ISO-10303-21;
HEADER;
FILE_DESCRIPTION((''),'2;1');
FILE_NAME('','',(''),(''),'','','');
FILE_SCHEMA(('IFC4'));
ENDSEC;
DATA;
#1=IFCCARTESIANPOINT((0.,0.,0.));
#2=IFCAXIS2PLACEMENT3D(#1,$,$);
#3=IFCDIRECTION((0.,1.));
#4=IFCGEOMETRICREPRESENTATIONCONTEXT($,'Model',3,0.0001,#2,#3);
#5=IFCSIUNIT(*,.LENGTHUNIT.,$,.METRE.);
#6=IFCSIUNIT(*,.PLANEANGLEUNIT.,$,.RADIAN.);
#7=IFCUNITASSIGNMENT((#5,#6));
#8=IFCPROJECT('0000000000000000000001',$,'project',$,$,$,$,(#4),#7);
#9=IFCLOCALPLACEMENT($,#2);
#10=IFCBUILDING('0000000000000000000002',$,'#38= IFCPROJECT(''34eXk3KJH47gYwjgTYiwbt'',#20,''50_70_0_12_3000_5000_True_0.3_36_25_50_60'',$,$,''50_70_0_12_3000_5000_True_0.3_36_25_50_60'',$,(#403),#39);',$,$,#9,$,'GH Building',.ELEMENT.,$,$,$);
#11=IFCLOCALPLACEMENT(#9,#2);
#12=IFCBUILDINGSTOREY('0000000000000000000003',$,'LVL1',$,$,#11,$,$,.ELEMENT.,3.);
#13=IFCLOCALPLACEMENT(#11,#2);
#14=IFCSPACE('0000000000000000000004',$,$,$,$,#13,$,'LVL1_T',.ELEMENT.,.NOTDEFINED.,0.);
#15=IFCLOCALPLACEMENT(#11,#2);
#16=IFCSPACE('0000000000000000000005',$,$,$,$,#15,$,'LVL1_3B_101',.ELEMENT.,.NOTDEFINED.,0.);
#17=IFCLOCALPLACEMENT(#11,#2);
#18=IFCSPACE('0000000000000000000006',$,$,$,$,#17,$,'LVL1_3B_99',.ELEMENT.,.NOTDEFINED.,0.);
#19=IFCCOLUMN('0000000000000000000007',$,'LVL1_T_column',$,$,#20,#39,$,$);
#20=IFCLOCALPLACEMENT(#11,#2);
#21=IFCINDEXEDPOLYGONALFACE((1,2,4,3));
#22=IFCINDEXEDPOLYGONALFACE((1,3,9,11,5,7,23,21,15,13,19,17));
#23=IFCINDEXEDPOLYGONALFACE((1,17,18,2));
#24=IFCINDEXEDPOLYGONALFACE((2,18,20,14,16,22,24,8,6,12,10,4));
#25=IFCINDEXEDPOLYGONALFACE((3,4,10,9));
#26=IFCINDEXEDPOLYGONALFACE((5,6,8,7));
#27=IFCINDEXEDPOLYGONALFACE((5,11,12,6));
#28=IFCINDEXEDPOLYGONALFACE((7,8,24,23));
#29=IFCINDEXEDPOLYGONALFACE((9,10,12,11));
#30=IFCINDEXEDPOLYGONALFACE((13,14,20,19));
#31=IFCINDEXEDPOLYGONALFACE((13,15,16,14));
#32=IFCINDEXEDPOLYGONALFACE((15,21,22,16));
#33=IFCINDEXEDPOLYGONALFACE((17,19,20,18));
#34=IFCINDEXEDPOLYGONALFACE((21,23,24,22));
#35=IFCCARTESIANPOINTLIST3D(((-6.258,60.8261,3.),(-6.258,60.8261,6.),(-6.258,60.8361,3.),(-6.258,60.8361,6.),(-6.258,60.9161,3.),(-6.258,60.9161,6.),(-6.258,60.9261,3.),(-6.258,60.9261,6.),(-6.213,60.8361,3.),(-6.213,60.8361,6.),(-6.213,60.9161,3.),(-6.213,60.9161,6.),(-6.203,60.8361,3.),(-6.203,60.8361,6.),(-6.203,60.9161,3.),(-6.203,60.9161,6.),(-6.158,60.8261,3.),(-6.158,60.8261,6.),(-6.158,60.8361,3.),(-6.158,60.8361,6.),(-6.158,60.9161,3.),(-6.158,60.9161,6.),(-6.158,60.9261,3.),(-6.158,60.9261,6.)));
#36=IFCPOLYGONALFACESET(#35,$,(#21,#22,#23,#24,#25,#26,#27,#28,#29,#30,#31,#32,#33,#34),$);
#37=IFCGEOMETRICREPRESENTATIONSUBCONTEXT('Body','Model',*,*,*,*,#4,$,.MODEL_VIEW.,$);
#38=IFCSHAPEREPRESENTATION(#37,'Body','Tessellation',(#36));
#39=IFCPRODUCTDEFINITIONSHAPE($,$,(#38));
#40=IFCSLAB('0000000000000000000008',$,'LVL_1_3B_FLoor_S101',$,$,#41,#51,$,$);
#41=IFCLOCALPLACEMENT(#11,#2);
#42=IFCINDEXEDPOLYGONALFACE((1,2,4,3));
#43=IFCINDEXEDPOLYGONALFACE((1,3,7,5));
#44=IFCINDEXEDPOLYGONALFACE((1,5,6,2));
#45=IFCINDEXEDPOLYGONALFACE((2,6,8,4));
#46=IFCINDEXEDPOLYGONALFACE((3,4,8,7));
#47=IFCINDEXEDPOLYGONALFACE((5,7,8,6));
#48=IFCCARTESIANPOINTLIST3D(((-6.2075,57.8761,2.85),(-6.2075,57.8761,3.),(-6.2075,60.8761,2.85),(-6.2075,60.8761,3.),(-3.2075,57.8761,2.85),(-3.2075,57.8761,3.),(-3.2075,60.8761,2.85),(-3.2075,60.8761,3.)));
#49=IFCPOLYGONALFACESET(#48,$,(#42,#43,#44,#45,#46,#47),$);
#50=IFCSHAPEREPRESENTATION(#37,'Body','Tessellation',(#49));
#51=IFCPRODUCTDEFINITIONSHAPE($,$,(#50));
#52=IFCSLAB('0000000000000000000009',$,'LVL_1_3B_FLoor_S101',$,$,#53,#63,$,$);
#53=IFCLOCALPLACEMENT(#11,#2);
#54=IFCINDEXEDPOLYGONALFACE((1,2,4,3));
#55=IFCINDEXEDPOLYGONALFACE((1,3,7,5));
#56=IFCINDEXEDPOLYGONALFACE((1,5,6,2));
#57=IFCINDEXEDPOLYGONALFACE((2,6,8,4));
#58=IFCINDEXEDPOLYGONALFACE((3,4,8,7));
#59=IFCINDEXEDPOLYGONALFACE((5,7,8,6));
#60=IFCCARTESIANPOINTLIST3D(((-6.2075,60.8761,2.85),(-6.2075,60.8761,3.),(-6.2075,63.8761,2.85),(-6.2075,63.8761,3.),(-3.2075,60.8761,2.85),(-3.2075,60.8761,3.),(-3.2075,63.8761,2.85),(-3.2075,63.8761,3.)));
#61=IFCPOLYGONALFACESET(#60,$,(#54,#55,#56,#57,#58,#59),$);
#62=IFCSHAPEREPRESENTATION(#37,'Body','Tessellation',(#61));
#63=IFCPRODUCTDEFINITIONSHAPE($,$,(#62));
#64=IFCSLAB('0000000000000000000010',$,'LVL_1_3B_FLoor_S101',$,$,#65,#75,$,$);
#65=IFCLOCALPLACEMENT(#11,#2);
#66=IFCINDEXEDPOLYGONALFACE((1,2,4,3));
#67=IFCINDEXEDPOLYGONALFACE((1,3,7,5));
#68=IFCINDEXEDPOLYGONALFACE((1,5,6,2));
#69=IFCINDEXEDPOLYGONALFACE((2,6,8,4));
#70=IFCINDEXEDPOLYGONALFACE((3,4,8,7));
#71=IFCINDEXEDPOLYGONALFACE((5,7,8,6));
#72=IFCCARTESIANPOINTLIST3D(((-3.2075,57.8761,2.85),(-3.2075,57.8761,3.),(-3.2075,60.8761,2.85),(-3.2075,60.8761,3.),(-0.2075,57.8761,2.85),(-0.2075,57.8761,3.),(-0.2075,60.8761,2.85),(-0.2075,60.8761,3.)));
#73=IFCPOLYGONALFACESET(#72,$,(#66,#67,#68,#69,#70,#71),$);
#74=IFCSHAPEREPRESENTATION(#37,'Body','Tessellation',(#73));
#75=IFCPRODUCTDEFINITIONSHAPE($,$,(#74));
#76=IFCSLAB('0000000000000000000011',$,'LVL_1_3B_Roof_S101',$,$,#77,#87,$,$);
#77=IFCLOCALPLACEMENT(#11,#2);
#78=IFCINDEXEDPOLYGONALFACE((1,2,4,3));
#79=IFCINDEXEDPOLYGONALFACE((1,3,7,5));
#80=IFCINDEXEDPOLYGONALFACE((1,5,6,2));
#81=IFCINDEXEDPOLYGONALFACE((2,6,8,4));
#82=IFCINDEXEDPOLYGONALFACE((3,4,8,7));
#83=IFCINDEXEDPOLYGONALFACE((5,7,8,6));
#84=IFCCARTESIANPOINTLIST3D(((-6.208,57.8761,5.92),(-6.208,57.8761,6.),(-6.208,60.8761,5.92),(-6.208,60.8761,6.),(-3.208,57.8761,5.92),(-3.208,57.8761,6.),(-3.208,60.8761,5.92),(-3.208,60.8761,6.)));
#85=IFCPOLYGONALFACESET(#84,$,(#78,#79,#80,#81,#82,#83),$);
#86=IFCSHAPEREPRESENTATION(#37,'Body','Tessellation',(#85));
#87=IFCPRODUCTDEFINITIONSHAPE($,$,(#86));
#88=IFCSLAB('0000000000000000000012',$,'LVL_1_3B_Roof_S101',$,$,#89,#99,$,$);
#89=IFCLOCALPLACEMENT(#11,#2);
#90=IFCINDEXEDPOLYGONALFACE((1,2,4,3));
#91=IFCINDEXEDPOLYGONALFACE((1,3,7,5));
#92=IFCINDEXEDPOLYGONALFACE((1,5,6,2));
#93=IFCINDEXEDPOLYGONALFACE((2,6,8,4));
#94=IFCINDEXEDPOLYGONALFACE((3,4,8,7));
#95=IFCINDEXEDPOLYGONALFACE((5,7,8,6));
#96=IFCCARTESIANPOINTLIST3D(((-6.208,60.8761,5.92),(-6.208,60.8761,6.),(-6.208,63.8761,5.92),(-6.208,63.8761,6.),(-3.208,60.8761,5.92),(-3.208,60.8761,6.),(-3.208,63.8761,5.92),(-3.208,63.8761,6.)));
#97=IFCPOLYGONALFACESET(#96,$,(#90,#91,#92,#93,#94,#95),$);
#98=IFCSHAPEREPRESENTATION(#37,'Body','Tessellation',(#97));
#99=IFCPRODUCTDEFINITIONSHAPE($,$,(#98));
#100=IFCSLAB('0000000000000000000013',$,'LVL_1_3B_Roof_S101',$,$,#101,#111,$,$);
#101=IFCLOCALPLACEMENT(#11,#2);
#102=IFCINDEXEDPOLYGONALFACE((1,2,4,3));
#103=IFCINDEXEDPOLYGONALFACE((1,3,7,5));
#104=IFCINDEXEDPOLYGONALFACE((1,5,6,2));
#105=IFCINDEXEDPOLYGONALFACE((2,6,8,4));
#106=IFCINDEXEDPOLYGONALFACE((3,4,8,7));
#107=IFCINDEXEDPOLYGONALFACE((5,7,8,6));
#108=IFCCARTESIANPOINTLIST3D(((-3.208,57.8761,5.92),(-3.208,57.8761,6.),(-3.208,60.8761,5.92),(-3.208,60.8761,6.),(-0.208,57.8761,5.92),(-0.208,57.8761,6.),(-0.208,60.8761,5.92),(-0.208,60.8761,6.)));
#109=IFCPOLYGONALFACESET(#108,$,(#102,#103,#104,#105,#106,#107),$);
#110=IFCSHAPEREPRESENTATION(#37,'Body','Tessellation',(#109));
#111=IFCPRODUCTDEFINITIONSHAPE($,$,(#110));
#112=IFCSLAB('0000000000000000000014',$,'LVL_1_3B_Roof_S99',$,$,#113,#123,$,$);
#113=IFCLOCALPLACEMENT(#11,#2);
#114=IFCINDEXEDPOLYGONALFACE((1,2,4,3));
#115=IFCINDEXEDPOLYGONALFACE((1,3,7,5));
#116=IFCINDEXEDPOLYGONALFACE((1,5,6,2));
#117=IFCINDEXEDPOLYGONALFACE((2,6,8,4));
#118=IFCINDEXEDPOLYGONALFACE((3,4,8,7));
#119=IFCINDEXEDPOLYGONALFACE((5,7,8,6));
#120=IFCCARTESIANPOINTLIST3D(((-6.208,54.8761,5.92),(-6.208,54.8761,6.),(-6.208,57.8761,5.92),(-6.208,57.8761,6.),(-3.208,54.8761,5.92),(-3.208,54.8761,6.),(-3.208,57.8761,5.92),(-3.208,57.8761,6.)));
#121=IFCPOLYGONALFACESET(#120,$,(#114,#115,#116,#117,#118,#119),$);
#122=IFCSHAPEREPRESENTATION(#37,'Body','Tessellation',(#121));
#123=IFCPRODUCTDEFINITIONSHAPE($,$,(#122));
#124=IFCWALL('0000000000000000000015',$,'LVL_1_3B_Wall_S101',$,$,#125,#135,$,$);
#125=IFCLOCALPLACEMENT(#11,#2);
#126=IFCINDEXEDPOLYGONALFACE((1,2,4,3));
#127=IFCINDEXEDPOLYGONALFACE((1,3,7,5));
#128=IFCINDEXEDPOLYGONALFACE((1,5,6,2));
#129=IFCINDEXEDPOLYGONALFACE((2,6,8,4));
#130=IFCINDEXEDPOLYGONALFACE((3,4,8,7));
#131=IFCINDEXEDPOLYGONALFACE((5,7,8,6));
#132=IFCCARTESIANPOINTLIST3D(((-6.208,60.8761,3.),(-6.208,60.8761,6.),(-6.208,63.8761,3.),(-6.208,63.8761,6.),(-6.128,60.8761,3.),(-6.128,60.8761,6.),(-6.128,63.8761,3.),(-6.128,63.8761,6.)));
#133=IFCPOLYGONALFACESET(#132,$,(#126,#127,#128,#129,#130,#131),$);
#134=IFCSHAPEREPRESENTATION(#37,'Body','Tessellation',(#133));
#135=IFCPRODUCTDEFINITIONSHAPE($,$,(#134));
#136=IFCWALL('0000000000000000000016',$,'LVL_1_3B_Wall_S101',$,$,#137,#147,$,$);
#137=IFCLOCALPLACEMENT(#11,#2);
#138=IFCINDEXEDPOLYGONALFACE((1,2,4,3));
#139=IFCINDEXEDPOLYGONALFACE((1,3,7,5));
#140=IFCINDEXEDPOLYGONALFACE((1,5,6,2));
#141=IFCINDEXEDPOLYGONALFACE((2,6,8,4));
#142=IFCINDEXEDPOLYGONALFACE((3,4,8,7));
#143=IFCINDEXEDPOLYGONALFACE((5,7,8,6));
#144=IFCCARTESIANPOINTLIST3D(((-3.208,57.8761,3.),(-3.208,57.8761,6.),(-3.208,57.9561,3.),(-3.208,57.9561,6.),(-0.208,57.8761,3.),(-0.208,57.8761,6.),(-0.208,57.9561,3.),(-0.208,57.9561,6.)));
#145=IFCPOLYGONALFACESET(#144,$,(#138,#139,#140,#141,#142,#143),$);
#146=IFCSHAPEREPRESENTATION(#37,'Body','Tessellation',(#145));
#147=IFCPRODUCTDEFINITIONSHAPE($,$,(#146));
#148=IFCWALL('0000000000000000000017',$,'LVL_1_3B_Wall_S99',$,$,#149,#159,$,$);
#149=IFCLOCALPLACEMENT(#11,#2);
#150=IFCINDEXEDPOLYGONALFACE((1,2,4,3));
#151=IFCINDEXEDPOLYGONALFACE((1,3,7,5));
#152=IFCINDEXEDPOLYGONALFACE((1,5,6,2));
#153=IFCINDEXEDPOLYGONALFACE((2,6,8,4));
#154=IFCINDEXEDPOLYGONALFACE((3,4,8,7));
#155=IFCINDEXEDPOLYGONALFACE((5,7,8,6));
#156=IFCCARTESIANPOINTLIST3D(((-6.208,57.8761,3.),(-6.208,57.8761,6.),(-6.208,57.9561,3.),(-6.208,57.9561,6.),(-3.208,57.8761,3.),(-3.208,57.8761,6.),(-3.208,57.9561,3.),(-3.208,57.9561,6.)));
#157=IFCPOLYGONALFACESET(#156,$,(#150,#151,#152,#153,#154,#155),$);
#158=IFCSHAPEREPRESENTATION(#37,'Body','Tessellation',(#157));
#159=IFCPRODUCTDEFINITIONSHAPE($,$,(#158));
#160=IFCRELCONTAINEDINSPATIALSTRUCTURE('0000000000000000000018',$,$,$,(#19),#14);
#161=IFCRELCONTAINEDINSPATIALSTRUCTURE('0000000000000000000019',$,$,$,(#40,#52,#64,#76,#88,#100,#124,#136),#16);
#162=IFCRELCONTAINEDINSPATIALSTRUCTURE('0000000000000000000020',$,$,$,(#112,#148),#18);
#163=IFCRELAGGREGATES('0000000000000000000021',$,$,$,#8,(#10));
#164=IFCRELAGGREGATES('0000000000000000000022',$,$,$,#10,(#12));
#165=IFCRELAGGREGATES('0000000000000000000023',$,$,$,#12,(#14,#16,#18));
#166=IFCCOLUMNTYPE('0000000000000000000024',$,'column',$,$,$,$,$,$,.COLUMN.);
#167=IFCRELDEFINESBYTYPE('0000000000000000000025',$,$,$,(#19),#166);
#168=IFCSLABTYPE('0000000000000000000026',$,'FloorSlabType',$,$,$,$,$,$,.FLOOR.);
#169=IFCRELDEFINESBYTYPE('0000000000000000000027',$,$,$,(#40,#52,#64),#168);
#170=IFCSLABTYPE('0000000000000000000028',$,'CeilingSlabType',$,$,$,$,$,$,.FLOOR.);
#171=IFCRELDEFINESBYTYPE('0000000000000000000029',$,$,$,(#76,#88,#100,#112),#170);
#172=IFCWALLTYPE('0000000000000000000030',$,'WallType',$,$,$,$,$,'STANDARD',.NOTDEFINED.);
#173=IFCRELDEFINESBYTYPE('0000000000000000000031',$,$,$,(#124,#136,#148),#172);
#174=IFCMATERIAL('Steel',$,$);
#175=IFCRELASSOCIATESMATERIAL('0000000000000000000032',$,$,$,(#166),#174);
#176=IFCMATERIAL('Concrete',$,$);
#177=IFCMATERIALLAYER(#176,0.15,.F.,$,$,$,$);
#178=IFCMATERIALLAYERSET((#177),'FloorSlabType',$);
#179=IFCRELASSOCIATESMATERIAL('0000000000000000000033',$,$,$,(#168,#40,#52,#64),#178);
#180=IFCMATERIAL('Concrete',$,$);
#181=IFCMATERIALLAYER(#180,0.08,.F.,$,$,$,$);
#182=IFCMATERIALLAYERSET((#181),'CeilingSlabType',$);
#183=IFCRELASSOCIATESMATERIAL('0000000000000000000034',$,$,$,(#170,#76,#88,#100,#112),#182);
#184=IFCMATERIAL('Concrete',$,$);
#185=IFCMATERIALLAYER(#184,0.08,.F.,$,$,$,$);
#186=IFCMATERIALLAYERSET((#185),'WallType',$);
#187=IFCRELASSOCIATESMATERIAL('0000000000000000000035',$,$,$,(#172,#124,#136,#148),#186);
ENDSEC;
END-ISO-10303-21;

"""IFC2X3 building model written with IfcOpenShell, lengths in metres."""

from ifc_helpers import new_model, si_unit, direction, frame, frame_2d, origin, origin_2d, place, context, subcontext, project, spatial, rectangle, i_section, extrude, material, layer, layer_set, layer_usage, type_object, element, save


model = new_model("IFC2X3")

# Units and contexts
model_context = context("Model", 3, precision=0.0001, world=origin(), true_north=direction((0.0, 1.0)))
body_context = subcontext(model_context, "Body", "Model", "MODEL_VIEW")
ifc_project = project(units=[si_unit("LENGTHUNIT", "METRE"), si_unit("PLANEANGLEUNIT", "RADIAN")], contexts=[model_context])

# Building, storey, space
building_placement = place(None, origin())
building = spatial("IfcBuilding", under=ifc_project, at=building_placement, Name="#38= IFCPROJECT('34eXk3KJH47gYwjgTYiwbt',#20,'50_70_0_12_3000_5000_True_0.3_36_25_50_60',$,$,'50_70_0_12_3000_5000_True_0.3_36_25_50_60',$,(#403),#39);", LongName="GH Building", CompositionType="ELEMENT")
storey_placement = place(building_placement, origin())
storey = spatial("IfcBuildingStorey", under=building, at=storey_placement, Name="LVL1", CompositionType="ELEMENT", Elevation=3.0)
space_1_placement = place(storey_placement, origin())
space_1 = spatial("IfcSpace", under=storey, at=space_1_placement, LongName="LVL1_T", CompositionType="ELEMENT", InteriorOrExteriorSpace="NOTDEFINED", ElevationWithFlooring=0.0)

# Column
ifc_material_1 = material(Name="Steel")
column_type = type_object("IfcColumnType", Name="column", PredefinedType="COLUMN", material=ifc_material_1)
column_placement = place(space_1_placement, frame((-6.208, 60.8761, 3.0)))
element("IfcColumn", 1, at=column_placement, inside=space_1, type_object=column_type, Name="LVL1_T_column", context=body_context, shape_type="SweptSolid", body=[
    extrude(i_section(OverallWidth=0.1, OverallDepth=0.1, WebThickness=0.01, FlangeThickness=0.01, at=origin_2d()), origin(), (0.0, 0.0, 1.0), 3.0),
])

# Shared definitions
space_2_placement = place(storey_placement, origin())
space_2 = spatial("IfcSpace", under=storey, at=space_2_placement, LongName="LVL1_3B_101", CompositionType="ELEMENT", InteriorOrExteriorSpace="NOTDEFINED", ElevationWithFlooring=0.0)

# Slabs
ifc_material_2 = material(Name="Concrete")
ifc_layer_1 = layer(ifc_material_2, 0.15, ventilated=False)
ifc_layer_set_1 = layer_set([ifc_layer_1], Name="FloorSlabType")
ifc_layer_usage_1 = layer_usage(ifc_layer_set_1, "AXIS3", "NEGATIVE", -0.15)
slab_type_1 = type_object("IfcSlabType", Name="FloorSlabType", PredefinedType="FLOOR", material=ifc_layer_set_1)
slab_1_placement = place(space_2_placement, frame((-3.2075, 57.8761, 2.85), z_axis=(0.0, 0.0, 1.0), x_axis=(0.0, 1.0, 0.0)))
element("IfcSlab", 2, at=slab_1_placement, inside=space_2, type_object=slab_type_1, material=ifc_layer_usage_1, Name="LVL_1_3B_FLoor_S101", context=body_context, shape_type="SweptSolid", body=[
    extrude(rectangle(XDim=3.0, YDim=3.0, at=frame_2d((1.5, 1.5))), origin(), (0.0, 0.0, 1.0), 0.15),
])
ifc_layer_usage_2 = layer_usage(ifc_layer_set_1, "AXIS3", "NEGATIVE", -0.15)
slab_2_placement = place(space_2_placement, frame((-3.2075, 60.8761, 2.85), z_axis=(0.0, 0.0, 1.0), x_axis=(0.0, 1.0, 0.0)))
element("IfcSlab", 3, at=slab_2_placement, inside=space_2, type_object=slab_type_1, material=ifc_layer_usage_2, Name="LVL_1_3B_FLoor_S101", context=body_context, shape_type="SweptSolid", body=[
    extrude(rectangle(XDim=3.0, YDim=3.0, at=frame_2d((1.5, 1.5))), origin(), (0.0, 0.0, 1.0), 0.15),
])
ifc_layer_usage_3 = layer_usage(ifc_layer_set_1, "AXIS3", "NEGATIVE", -0.15)
slab_3_placement = place(space_2_placement, frame((-0.2075, 57.8761, 2.85), z_axis=(0.0, 0.0, 1.0), x_axis=(0.0, 1.0, 0.0)))
element("IfcSlab", 4, at=slab_3_placement, inside=space_2, type_object=slab_type_1, material=ifc_layer_usage_3, Name="LVL_1_3B_FLoor_S101", context=body_context, shape_type="SweptSolid", body=[
    extrude(rectangle(XDim=3.0, YDim=3.0, at=frame_2d((1.5, 1.5))), origin(), (0.0, 0.0, 1.0), 0.15),
])
ifc_material_3 = material(Name="Concrete")
ifc_layer_2 = layer(ifc_material_3, 0.08, ventilated=False)
ifc_layer_set_2 = layer_set([ifc_layer_2], Name="CeilingSlabType")
ifc_layer_usage_4 = layer_usage(ifc_layer_set_2, "AXIS3", "NEGATIVE", -0.08)
slab_type_2 = type_object("IfcSlabType", Name="CeilingSlabType", PredefinedType="FLOOR", material=ifc_layer_set_2)
slab_4_placement = place(space_2_placement, frame((-3.208, 57.8761, 5.92), z_axis=(0.0, 0.0, 1.0), x_axis=(0.0, 1.0, 0.0)))
element("IfcSlab", 5, at=slab_4_placement, inside=space_2, type_object=slab_type_2, material=ifc_layer_usage_4, Name="LVL_1_3B_Roof_S101", context=body_context, shape_type="SweptSolid", body=[
    extrude(rectangle(XDim=3.0, YDim=3.0, at=frame_2d((1.5, 1.5))), origin(), (0.0, 0.0, 1.0), 0.08),
])
ifc_layer_usage_5 = layer_usage(ifc_layer_set_2, "AXIS3", "NEGATIVE", -0.08)
slab_5_placement = place(space_2_placement, frame((-3.208, 60.8761, 5.92), z_axis=(0.0, 0.0, 1.0), x_axis=(0.0, 1.0, 0.0)))
element("IfcSlab", 6, at=slab_5_placement, inside=space_2, type_object=slab_type_2, material=ifc_layer_usage_5, Name="LVL_1_3B_Roof_S101", context=body_context, shape_type="SweptSolid", body=[
    extrude(rectangle(XDim=3.0, YDim=3.0, at=frame_2d((1.5, 1.5))), origin(), (0.0, 0.0, 1.0), 0.08),
])
ifc_layer_usage_6 = layer_usage(ifc_layer_set_2, "AXIS3", "NEGATIVE", -0.08)
slab_6_placement = place(space_2_placement, frame((-0.208, 57.8761, 5.92), z_axis=(0.0, 0.0, 1.0), x_axis=(0.0, 1.0, 0.0)))
element("IfcSlab", 7, at=slab_6_placement, inside=space_2, type_object=slab_type_2, material=ifc_layer_usage_6, Name="LVL_1_3B_Roof_S101", context=body_context, shape_type="SweptSolid", body=[
    extrude(rectangle(XDim=3.0, YDim=3.0, at=frame_2d((1.5, 1.5))), origin(), (0.0, 0.0, 1.0), 0.08),
])

# Shared definitions
space_3_placement = place(storey_placement, origin())
space_3 = spatial("IfcSpace", under=storey, at=space_3_placement, LongName="LVL1_3B_99", CompositionType="ELEMENT", InteriorOrExteriorSpace="NOTDEFINED", ElevationWithFlooring=0.0)

# Slab
ifc_layer_usage_7 = layer_usage(ifc_layer_set_2, "AXIS3", "NEGATIVE", -0.08)
slab_7_placement = place(space_3_placement, frame((-3.208, 57.8761, 5.92), z_axis=(0.0, 0.0, 1.0), x_axis=(0.0, -1.0, 0.0)))
element("IfcSlab", 8, at=slab_7_placement, inside=space_3, type_object=slab_type_2, material=ifc_layer_usage_7, Name="LVL_1_3B_Roof_S99", context=body_context, shape_type="SweptSolid", body=[
    extrude(rectangle(XDim=3.0, YDim=3.0, at=frame_2d((1.5, -1.5))), origin(), (0.0, 0.0, 1.0), 0.08),
])

# Shared definitions
ifc_material_4 = material(Name="Concrete")
ifc_layer_3 = layer(ifc_material_4, 0.08, ventilated=False)
ifc_layer_set_3 = layer_set([ifc_layer_3], Name="WallType")
wall_type = type_object("IfcWallType", Name="WallType", ElementType="STANDARD", PredefinedType="NOTDEFINED", material=ifc_layer_set_3)

# Walls
ifc_layer_usage_8 = layer_usage(ifc_layer_set_3, "AXIS2", "NEGATIVE", 0.0)
wall_1_placement = place(space_2_placement, frame((-6.208, 60.8761, 3.0), z_axis=(0.0, 0.0, 1.0), x_axis=(0.0, 1.0, 0.0)))
element("IfcWall", 9, at=wall_1_placement, inside=space_2, type_object=wall_type, material=ifc_layer_usage_8, Name="LVL_1_3B_Wall_S101", context=body_context, shape_type="SweptSolid", body=[
    extrude(rectangle(XDim=3.0, YDim=0.08, at=frame_2d((1.5, -0.04))), origin(), (0.0, 0.0, 1.0), 3.0),
])
ifc_layer_usage_9 = layer_usage(ifc_layer_set_3, "AXIS2", "NEGATIVE", 0.0)
wall_2_placement = place(space_2_placement, frame((-0.208, 57.8761, 3.0), z_axis=(0.0, 0.0, 1.0), x_axis=(-1.0, 0.0, 0.0)))
element("IfcWall", 10, at=wall_2_placement, inside=space_2, type_object=wall_type, material=ifc_layer_usage_9, Name="LVL_1_3B_Wall_S101", context=body_context, shape_type="SweptSolid", body=[
    extrude(rectangle(XDim=3.0, YDim=0.08, at=frame_2d((1.5, -0.04))), origin(), (0.0, 0.0, 1.0), 3.0),
])
ifc_layer_usage_10 = layer_usage(ifc_layer_set_3, "AXIS2", "NEGATIVE", 0.0)
wall_3_placement = place(space_3_placement, frame((-3.208, 57.8761, 3.0), z_axis=(0.0, 0.0, 1.0), x_axis=(-1.0, 0.0, 0.0)))
element("IfcWall", 11, at=wall_3_placement, inside=space_3, type_object=wall_type, material=ifc_layer_usage_10, Name="LVL_1_3B_Wall_S99", context=body_context, shape_type="SweptSolid", body=[
    extrude(rectangle(XDim=3.0, YDim=0.08, at=frame_2d((1.5, -0.04))), origin(), (0.0, 0.0, 1.0), 3.0),
])

save(model, "model.ifc")
